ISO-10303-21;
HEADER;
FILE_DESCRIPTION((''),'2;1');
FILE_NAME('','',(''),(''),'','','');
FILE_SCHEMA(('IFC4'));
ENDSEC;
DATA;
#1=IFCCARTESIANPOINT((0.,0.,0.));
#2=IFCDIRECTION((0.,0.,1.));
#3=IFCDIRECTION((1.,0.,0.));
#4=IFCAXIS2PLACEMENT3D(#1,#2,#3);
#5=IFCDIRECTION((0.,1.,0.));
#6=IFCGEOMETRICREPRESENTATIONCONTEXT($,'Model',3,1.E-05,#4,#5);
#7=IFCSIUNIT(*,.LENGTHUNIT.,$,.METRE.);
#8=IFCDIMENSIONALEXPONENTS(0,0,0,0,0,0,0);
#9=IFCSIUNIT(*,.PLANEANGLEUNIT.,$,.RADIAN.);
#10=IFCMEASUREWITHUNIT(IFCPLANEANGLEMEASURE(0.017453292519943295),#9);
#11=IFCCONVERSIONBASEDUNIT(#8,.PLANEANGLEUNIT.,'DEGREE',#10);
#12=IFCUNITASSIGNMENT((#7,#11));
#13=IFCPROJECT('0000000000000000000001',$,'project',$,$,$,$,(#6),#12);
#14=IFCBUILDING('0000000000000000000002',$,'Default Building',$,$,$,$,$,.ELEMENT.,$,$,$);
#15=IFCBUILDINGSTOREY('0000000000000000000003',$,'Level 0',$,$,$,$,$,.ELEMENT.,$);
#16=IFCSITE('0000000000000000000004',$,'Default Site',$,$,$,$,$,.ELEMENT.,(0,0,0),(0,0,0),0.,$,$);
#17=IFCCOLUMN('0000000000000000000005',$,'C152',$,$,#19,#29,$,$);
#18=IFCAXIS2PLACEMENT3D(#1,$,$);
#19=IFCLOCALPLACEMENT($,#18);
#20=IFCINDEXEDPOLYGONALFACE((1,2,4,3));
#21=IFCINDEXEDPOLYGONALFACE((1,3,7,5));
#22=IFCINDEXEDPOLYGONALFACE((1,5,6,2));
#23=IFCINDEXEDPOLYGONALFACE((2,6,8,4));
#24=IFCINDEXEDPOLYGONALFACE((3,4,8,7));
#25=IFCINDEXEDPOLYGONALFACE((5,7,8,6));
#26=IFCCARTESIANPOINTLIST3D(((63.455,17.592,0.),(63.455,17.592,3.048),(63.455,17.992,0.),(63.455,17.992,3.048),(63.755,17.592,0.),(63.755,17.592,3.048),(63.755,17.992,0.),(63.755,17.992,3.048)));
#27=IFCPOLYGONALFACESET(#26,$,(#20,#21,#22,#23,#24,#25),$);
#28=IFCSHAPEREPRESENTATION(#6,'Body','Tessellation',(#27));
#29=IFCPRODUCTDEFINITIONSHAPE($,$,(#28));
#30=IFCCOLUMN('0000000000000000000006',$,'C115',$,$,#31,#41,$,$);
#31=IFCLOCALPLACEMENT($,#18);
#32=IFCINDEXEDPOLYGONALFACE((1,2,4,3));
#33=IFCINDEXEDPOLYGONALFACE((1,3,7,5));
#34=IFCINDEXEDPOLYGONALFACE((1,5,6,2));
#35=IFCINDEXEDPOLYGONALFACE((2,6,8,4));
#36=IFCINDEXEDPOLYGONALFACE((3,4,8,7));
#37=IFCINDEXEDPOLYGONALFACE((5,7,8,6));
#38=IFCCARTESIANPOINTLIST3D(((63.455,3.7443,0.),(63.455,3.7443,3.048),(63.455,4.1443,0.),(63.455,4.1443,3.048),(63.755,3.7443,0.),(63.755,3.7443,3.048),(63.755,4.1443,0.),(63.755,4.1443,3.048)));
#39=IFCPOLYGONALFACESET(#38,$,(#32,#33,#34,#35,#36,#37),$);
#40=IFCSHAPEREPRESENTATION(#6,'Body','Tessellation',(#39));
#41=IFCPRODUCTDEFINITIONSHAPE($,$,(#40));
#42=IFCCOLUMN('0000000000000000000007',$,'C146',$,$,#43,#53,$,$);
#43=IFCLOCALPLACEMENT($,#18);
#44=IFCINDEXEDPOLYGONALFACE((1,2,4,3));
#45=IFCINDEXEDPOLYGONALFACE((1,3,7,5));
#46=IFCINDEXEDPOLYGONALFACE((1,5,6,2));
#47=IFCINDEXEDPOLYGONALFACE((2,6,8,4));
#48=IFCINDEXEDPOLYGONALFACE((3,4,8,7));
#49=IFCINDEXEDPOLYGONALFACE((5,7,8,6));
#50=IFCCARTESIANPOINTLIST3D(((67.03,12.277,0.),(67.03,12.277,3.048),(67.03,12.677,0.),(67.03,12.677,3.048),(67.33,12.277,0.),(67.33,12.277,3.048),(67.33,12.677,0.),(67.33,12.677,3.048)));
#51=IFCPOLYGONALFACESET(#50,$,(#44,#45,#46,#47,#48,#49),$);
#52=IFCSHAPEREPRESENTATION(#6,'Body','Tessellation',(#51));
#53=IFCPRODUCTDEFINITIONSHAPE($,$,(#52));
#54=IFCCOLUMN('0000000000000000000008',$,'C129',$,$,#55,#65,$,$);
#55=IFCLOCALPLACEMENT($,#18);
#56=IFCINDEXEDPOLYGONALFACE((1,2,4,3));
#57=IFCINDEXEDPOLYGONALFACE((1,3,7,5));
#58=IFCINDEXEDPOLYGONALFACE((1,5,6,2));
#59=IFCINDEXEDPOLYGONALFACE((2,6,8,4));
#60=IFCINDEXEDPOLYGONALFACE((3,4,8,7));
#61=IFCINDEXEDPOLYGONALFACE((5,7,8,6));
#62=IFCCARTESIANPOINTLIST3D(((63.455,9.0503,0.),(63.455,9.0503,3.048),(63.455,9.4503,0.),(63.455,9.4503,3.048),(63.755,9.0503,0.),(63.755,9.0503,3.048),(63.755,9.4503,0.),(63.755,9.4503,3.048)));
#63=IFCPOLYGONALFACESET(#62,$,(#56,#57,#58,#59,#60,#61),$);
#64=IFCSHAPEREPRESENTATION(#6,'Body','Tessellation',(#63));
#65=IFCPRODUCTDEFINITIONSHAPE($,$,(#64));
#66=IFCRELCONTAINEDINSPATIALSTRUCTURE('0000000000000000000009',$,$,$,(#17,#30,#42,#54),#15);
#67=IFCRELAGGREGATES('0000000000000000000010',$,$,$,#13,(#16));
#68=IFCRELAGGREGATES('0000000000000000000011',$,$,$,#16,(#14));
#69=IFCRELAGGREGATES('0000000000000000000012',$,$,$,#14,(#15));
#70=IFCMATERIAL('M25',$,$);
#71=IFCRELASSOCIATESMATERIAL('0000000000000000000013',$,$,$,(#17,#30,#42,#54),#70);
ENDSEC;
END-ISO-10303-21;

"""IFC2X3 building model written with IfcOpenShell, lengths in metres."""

from ifc_helpers import new_model, entity, si_unit, converted_unit, direction, frame, frame_2d, origin_with_axes, place, context, project, spatial, rectangle, extrude, material, element, save


model = new_model("IFC2X3")

# Units and contexts
model_context = context("Model", 3, precision=1e-05, world=origin_with_axes(), true_north=direction((0.0, 1.0, 0.0)))
ifc_project = project(units=[si_unit("LENGTHUNIT", "METRE"), converted_unit("PLANEANGLEUNIT", "DEGREE", entity("IfcPlaneAngleMeasure", 0.017453292519943295), si_unit("PLANEANGLEUNIT", "RADIAN"), dimensions=[0, 0, 0, 0, 0, 0, 0])], contexts=[model_context])

# Site, building, storey
site = spatial("IfcSite", under=ifc_project, Name="Default Site", CompositionType="ELEMENT", RefLatitude=(0, 0, 0), RefLongitude=(0, 0, 0), RefElevation=0.0)
building = spatial("IfcBuilding", under=site, Name="Default Building", CompositionType="ELEMENT")
storey = spatial("IfcBuildingStorey", under=building, Name="Level 0", CompositionType="ELEMENT")

# Columns
ifc_material = material(Name="M25")
placement = place(None, origin_with_axes())
element("IfcColumn", 1, at=placement, inside=storey, material=ifc_material, Name="C152", context=model_context, shape_type="SweptSolid", body=[
    extrude(rectangle(XDim=0.3, YDim=0.4, at=frame_2d((0.0, 0.0), x_axis=(1.0, 0.0, 0.0))), frame((63.605, 17.792, 0.0), z_axis=(0.0, 0.0, 1.0), x_axis=(1.0, 0.0, 0.0)), (0.0, 0.0, 1.0), 3.048),
])
element("IfcColumn", 2, at=placement, inside=storey, material=ifc_material, Name="C115", context=model_context, shape_type="SweptSolid", body=[
    extrude(rectangle(XDim=0.3, YDim=0.4, at=frame_2d((0.0, 0.0), x_axis=(1.0, 0.0, 0.0))), frame((63.605, 3.9443, 0.0), z_axis=(0.0, 0.0, 1.0), x_axis=(1.0, 0.0, 0.0)), (0.0, 0.0, 1.0), 3.048),
])
element("IfcColumn", 3, at=placement, inside=storey, material=ifc_material, Name="C146", context=model_context, shape_type="SweptSolid", body=[
    extrude(rectangle(XDim=0.3, YDim=0.4, at=frame_2d((0.0, 0.0), x_axis=(1.0, 0.0, 0.0))), frame((67.18, 12.477, 0.0), z_axis=(0.0, 0.0, 1.0), x_axis=(1.0, 0.0, 0.0)), (0.0, 0.0, 1.0), 3.048),
])
element("IfcColumn", 4, at=placement, inside=storey, material=ifc_material, Name="C129", context=model_context, shape_type="SweptSolid", body=[
    extrude(rectangle(XDim=0.3, YDim=0.4, at=frame_2d((0.0, 0.0), x_axis=(1.0, 0.0, 0.0))), frame((63.605, 9.2503, 0.0), z_axis=(0.0, 0.0, 1.0), x_axis=(1.0, 0.0, 0.0)), (0.0, 0.0, 1.0), 3.048),
])

save(model, "model.ifc")
